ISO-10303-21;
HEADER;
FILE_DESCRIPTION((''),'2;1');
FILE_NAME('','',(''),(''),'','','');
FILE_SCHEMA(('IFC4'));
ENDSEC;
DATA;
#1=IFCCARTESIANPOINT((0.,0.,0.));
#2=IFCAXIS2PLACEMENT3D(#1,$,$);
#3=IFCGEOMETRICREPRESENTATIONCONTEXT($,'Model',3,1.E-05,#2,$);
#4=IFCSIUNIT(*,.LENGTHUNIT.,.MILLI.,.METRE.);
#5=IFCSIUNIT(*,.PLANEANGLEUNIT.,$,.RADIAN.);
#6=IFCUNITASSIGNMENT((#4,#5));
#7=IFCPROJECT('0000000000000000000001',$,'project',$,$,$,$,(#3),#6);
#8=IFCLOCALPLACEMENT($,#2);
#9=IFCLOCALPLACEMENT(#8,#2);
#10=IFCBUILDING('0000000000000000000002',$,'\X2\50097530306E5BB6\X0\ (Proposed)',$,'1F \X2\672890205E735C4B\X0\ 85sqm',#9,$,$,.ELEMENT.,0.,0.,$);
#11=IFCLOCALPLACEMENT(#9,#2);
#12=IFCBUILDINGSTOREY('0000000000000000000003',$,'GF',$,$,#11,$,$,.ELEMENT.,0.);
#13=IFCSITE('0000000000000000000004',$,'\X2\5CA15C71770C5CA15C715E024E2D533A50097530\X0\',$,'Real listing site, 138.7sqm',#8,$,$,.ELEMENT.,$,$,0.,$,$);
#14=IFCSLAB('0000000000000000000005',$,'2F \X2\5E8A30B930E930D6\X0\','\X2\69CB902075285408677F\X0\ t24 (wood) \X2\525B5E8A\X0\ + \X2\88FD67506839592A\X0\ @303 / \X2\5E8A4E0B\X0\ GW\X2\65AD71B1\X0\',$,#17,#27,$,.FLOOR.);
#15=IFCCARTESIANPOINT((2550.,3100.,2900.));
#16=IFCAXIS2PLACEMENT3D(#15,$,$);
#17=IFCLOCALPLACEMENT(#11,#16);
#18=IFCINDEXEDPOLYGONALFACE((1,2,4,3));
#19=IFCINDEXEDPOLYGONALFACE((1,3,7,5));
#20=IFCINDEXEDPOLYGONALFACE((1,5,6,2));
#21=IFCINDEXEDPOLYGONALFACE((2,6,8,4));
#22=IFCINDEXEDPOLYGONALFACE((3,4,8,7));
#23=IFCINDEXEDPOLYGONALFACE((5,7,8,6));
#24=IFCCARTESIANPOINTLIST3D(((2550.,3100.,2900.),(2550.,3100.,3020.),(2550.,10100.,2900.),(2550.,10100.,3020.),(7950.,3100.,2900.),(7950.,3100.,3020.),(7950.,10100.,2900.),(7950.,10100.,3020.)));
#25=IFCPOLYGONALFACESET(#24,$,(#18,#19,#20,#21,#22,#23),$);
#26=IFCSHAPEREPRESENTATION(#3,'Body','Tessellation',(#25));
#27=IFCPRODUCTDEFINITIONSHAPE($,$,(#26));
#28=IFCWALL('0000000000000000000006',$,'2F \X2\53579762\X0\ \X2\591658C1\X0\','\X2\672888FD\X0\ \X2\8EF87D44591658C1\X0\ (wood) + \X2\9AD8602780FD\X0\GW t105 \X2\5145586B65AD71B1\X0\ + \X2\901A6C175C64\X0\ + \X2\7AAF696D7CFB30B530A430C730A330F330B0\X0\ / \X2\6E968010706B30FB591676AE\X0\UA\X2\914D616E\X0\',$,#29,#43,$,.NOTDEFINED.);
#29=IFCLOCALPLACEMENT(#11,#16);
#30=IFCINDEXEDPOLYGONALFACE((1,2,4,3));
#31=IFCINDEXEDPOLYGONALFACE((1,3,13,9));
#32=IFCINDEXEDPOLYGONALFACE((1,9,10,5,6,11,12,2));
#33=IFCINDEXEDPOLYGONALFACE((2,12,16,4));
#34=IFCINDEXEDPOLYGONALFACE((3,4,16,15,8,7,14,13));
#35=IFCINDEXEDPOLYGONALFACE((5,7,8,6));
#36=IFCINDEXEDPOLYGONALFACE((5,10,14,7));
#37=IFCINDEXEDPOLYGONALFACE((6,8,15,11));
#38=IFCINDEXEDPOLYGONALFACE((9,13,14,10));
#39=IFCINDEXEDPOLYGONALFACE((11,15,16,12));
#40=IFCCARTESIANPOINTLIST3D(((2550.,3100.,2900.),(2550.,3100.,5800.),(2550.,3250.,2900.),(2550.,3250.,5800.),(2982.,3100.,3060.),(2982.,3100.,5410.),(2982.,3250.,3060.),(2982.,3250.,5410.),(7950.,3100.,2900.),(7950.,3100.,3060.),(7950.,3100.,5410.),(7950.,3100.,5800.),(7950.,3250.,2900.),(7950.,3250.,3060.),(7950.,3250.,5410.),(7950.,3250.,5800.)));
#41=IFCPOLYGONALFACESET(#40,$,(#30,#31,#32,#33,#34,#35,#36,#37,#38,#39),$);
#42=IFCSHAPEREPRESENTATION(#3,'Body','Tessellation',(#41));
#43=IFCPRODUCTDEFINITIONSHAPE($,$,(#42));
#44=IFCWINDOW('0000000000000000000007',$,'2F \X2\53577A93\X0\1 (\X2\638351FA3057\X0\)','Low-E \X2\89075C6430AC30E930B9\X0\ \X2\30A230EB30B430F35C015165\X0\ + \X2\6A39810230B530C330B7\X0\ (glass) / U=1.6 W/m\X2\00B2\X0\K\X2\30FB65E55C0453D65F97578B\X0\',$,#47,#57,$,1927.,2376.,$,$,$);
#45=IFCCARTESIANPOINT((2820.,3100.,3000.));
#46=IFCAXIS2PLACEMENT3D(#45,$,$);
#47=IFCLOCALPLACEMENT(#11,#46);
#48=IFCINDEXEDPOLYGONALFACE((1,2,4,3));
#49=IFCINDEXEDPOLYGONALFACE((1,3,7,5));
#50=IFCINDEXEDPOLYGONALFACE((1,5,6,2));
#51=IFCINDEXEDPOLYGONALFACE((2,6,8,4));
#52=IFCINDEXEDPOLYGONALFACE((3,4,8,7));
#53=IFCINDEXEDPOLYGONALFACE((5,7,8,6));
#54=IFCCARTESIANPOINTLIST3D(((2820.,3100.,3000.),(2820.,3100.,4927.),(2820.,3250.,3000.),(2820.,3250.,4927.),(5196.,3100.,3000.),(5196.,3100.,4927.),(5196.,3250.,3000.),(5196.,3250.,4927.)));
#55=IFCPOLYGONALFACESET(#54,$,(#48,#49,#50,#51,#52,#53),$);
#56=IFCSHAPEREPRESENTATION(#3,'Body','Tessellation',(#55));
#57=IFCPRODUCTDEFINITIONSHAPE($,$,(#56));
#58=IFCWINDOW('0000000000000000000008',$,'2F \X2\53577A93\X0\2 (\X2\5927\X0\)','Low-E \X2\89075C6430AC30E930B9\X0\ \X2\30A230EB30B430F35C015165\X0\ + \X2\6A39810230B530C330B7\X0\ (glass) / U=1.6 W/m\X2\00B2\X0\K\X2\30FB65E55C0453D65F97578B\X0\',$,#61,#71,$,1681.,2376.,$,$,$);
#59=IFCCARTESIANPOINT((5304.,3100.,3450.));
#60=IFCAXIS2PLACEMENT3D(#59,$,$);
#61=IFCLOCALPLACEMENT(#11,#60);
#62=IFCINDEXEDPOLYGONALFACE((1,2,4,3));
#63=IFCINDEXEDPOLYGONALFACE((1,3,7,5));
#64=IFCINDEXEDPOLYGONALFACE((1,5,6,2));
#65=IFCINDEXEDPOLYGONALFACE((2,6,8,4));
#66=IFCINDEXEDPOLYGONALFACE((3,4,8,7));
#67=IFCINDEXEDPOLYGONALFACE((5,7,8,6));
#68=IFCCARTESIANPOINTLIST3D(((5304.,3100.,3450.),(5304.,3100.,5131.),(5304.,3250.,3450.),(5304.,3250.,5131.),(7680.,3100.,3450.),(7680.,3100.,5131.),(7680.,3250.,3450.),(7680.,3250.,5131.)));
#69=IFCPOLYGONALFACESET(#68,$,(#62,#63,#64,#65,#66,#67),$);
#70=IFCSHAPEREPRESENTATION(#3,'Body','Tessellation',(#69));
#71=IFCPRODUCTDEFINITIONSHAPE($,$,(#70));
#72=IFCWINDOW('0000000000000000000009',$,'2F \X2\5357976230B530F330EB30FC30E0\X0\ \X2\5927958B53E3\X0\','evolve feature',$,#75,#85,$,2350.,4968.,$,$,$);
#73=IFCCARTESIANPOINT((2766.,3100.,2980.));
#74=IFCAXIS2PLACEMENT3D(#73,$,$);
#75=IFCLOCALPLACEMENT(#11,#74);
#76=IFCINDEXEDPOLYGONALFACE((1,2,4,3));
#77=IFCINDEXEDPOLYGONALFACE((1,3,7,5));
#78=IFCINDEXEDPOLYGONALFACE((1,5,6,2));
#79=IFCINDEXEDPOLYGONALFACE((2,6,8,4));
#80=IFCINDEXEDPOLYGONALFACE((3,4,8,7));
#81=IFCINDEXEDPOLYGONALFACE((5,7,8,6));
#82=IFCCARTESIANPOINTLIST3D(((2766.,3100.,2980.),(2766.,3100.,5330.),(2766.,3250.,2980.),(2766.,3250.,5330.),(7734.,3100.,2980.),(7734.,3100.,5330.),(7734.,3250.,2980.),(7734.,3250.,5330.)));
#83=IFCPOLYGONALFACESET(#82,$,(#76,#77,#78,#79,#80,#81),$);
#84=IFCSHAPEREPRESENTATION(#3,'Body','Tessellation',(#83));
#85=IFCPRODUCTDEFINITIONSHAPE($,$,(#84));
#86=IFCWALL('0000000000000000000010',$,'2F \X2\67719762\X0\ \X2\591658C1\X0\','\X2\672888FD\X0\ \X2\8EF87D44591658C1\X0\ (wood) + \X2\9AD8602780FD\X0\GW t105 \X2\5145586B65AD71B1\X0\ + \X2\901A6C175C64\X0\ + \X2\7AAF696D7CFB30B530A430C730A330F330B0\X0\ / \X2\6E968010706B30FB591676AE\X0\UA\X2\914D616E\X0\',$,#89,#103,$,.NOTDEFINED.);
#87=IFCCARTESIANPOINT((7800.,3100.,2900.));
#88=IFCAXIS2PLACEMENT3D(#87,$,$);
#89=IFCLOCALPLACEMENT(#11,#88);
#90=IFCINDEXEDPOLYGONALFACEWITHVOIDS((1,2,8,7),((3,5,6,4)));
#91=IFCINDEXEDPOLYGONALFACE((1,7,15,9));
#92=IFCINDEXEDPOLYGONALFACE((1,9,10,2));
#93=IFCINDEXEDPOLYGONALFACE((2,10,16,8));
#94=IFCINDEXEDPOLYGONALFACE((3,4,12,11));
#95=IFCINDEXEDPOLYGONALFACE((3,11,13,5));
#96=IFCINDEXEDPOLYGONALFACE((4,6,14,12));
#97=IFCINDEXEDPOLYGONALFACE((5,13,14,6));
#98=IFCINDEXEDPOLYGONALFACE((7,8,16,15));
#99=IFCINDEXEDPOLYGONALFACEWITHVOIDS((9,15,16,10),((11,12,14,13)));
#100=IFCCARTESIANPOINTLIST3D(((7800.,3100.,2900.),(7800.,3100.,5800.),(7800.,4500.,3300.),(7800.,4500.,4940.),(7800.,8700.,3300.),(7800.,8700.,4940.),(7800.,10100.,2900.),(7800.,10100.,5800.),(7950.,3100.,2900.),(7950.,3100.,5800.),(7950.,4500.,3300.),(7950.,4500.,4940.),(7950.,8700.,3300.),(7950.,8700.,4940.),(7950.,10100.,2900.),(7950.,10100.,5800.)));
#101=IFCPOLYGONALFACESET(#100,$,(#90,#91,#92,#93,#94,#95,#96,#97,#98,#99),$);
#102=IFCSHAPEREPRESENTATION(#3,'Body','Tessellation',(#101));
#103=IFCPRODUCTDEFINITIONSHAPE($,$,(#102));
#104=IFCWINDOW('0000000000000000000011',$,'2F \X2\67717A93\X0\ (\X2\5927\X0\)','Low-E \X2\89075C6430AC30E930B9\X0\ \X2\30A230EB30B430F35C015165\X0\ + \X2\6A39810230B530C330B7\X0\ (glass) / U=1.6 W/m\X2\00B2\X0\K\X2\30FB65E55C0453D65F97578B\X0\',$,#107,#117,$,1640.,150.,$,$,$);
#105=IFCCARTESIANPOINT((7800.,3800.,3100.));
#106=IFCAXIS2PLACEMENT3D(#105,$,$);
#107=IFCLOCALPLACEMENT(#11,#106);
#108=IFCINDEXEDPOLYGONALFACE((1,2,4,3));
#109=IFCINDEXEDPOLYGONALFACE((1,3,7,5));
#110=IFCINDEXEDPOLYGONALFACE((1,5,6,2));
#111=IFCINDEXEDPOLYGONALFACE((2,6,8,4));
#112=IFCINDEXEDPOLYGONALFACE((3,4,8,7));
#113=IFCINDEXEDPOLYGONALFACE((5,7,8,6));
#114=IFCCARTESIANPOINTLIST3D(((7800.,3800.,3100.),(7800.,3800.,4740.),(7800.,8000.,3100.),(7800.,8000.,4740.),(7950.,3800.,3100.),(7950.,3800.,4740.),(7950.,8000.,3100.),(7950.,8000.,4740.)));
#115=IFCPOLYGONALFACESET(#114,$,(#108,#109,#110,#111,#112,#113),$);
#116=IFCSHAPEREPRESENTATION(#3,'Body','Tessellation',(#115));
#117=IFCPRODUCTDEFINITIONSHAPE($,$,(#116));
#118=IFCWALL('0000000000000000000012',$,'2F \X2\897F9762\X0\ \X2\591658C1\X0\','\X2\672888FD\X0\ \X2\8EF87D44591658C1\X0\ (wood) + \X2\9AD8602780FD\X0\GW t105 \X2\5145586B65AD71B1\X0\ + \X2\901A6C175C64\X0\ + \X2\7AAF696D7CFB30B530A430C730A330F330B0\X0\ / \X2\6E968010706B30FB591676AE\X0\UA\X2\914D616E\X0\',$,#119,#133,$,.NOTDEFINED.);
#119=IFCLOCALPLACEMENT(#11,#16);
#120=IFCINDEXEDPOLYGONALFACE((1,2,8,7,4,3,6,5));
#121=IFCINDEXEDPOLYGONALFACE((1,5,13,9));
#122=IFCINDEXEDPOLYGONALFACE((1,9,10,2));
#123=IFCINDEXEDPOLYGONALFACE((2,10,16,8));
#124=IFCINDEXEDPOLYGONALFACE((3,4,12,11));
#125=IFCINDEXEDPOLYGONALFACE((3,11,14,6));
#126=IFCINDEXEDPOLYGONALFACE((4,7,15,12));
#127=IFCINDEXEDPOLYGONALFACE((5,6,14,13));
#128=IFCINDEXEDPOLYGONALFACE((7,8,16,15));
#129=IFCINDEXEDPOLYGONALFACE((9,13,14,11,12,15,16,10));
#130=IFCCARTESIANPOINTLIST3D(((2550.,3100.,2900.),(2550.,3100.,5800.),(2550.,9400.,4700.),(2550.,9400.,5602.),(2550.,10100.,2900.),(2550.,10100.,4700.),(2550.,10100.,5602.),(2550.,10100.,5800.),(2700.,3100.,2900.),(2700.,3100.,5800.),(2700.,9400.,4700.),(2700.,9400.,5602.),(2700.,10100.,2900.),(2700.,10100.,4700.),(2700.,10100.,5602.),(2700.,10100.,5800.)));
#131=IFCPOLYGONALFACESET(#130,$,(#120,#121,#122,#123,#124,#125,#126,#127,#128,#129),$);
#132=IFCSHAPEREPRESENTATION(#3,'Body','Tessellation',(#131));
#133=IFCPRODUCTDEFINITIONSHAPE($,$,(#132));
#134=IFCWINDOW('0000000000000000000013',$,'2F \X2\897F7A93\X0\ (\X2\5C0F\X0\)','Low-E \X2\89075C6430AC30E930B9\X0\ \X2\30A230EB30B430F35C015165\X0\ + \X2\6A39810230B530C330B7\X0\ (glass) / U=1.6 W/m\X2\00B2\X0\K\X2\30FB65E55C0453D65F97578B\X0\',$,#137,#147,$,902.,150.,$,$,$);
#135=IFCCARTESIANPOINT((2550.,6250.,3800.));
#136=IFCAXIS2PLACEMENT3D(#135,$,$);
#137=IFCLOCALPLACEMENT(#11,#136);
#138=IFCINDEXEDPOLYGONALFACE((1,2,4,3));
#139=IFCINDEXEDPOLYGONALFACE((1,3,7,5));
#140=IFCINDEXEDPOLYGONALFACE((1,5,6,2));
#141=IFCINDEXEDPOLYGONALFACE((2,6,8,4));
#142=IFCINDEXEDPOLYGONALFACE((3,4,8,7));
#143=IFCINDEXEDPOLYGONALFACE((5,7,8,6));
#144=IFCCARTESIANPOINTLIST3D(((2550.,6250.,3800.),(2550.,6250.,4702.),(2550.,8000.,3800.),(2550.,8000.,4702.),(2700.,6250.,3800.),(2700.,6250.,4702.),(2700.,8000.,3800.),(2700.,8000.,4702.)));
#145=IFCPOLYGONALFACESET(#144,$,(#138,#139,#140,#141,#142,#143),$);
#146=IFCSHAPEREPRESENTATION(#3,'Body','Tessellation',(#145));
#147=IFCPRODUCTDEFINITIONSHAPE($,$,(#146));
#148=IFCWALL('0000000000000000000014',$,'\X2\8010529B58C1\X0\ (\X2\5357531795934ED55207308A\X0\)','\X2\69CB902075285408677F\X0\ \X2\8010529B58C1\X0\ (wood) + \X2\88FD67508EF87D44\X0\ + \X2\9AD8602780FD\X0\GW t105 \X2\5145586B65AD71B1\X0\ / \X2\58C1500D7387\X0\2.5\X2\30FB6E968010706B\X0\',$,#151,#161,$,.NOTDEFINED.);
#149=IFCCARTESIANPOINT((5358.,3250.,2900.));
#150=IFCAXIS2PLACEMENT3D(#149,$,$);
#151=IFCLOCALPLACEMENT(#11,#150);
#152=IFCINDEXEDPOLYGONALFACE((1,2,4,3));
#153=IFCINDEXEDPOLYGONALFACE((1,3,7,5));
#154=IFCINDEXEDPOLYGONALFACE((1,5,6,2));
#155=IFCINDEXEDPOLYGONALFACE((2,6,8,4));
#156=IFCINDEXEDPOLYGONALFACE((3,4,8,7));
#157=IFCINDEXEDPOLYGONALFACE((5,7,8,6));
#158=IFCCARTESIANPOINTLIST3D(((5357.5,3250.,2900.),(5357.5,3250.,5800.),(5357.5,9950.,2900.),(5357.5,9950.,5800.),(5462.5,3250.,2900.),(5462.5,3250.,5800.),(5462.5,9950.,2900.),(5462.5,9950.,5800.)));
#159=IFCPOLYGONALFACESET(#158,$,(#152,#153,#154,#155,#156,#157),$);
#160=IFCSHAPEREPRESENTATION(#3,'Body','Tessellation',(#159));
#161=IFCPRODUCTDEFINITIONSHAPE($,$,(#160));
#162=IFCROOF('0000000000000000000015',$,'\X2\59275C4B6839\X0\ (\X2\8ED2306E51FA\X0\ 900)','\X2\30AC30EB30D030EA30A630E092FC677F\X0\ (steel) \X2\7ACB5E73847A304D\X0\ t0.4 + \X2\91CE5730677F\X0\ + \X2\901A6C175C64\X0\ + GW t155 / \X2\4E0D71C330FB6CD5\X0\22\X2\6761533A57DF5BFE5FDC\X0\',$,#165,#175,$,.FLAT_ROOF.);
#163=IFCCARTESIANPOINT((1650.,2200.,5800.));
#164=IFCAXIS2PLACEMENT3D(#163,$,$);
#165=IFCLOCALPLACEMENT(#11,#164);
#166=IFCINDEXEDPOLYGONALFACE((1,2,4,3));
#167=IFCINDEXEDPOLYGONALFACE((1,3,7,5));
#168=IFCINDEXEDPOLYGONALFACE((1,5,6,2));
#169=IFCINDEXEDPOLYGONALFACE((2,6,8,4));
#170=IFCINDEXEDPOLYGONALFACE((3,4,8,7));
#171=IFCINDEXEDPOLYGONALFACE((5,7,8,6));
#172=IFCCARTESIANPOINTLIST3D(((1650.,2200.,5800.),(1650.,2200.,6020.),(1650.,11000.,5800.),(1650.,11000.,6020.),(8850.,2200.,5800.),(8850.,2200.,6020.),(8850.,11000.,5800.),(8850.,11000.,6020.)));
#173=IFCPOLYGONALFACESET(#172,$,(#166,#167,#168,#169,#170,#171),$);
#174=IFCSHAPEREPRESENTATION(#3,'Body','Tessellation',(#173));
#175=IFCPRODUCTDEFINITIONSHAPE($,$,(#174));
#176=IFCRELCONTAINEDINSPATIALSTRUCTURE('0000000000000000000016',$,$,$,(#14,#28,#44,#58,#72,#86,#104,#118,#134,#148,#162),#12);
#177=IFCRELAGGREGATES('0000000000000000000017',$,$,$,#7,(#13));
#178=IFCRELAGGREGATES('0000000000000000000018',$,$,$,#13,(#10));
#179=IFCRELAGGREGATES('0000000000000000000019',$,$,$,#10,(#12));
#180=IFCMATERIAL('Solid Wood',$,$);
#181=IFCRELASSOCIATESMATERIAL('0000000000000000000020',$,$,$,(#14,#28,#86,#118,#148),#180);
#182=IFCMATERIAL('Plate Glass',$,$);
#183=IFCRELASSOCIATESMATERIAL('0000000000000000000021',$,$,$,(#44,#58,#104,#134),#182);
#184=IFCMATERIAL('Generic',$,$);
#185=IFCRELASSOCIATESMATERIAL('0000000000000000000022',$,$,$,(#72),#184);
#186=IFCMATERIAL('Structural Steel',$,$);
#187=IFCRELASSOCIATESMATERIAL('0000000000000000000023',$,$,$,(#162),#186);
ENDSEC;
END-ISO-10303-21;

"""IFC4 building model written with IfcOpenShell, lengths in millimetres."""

from ifc_helpers import new_model, si_unit, frame, frame_2d, origin, place, context, project, spatial, rectangle, extrude, material, element, fill, save


model = new_model("IFC4")

# Units and contexts
model_context = context("Model", 3, precision=1e-05, world=origin())
ifc_project = project(units=[si_unit("LENGTHUNIT", "METRE", prefix="MILLI"), si_unit("PLANEANGLEUNIT", "RADIAN")], contexts=[model_context])

# Site, building, storey
site_placement = place(None, origin())
site = spatial("IfcSite", under=ifc_project, at=site_placement, Name="岡山県岡山市中区倉田", ObjectType="Real listing site, 138.7sqm", CompositionType="ELEMENT", RefElevation=0.0)
building_placement = place(site_placement, origin())
building = spatial("IfcBuilding", under=site, at=building_placement, Name="倉田の家 (Proposed)", ObjectType="1F 木造平屋 85sqm", CompositionType="ELEMENT", ElevationOfRefHeight=0.0, ElevationOfTerrain=0.0)
storey_placement = place(building_placement, origin())
storey = spatial("IfcBuildingStorey", under=building, at=storey_placement, Name="GF", CompositionType="ELEMENT", Elevation=0.0)

# Slab
ifc_material_1 = material(Name="Solid Wood")
slab_placement = place(storey_placement, frame((2550.0, 3100.0, 2900.0)))
element("IfcSlab", 1, at=slab_placement, inside=storey, material=ifc_material_1, Name="2F 床スラブ", Description="構造用合板 t24 (wood) 剛床 + 製材根太 @303 / 床下 GW断熱", PredefinedType="FLOOR", context=model_context, shape_type="SweptSolid", body=[
    extrude(rectangle(XDim=5400.0, YDim=7000.0, at=frame_2d((2700.0, 3500.0))), frame((2550.0, 3100.0, 2900.0)), (0.0, 0.0, 1.0), 120.0),
])

# Wall, openings, windows
wall_1_placement = place(storey_placement, frame((2550.0, 3100.0, 2900.0)))
wall_1 = element("IfcWall", 2, at=wall_1_placement, inside=storey, material=ifc_material_1, Name="2F 南面 外壁", Description="木製 軸組外壁 (wood) + 高性能GW t105 充填断熱 + 通気層 + 窯業系サイディング / 準耐火・外皮UA配慮", PredefinedType="NOTDEFINED", context=model_context, shape_type="SweptSolid", body=[
    extrude(rectangle(XDim=5400.0, YDim=150.0, at=frame_2d((2700.0, 75.0))), frame((2550.0, 3100.0, 2900.0)), (0.0, 0.0, 1.0), 2900.0),
])
opening_1_placement = place(storey_placement, frame((2820.0, 3100.0, 3000.0)))
opening_1 = element("IfcOpeningElement", 3, at=opening_1_placement, cuts=wall_1, PredefinedType="NOTDEFINED", context=model_context, shape_type="SweptSolid", body=[
    extrude(rectangle(XDim=2376.0, YDim=150.0, at=frame_2d((1188.0, 75.0))), frame((2820.0, 3100.0, 3000.0)), (0.0, 0.0, 1.0), 1927.0),
])
opening_2_placement = place(storey_placement, frame((5304.0, 3100.0, 3450.0)))
opening_2 = element("IfcOpeningElement", 4, at=opening_2_placement, cuts=wall_1, PredefinedType="NOTDEFINED", context=model_context, shape_type="SweptSolid", body=[
    extrude(rectangle(XDim=2376.0, YDim=150.0, at=frame_2d((1188.0, 75.0))), frame((5304.0, 3100.0, 3450.0)), (0.0, 0.0, 1.0), 1681.0),
])
opening_3_placement = place(storey_placement, frame((2766.0, 3100.0, 2980.0)))
opening_3 = element("IfcOpeningElement", 5, at=opening_3_placement, cuts=wall_1, PredefinedType="NOTDEFINED", context=model_context, shape_type="SweptSolid", body=[
    extrude(rectangle(XDim=4968.0, YDim=150.0, at=frame_2d((2484.0, 75.0))), frame((2766.0, 3100.0, 2980.0)), (0.0, 0.0, 1.0), 2350.0),
])
ifc_material_2 = material(Name="Plate Glass")
window_1_placement = place(storey_placement, frame((2820.0, 3100.0, 3000.0)))
window_1 = element("IfcWindow", 6, at=window_1_placement, inside=storey, material=ifc_material_2, Name="2F 南窓1 (掃出し)", Description="Low-E 複層ガラス アルゴン封入 + 樹脂サッシ (glass) / U=1.6 W/m²K・日射取得型", OverallHeight=1927.0, OverallWidth=2376.0, context=model_context, shape_type="SweptSolid", body=[
    extrude(rectangle(XDim=2376.0, YDim=150.0, at=frame_2d((1188.0, 75.0))), frame((2820.0, 3100.0, 3000.0)), (0.0, 0.0, 1.0), 1927.0),
])
fill(opening_1, window_1)
window_2_placement = place(storey_placement, frame((5304.0, 3100.0, 3450.0)))
window_2 = element("IfcWindow", 7, at=window_2_placement, inside=storey, material=ifc_material_2, Name="2F 南窓2 (大)", Description="Low-E 複層ガラス アルゴン封入 + 樹脂サッシ (glass) / U=1.6 W/m²K・日射取得型", OverallHeight=1681.0, OverallWidth=2376.0, context=model_context, shape_type="SweptSolid", body=[
    extrude(rectangle(XDim=2376.0, YDim=150.0, at=frame_2d((1188.0, 75.0))), frame((5304.0, 3100.0, 3450.0)), (0.0, 0.0, 1.0), 1681.0),
])
fill(opening_2, window_2)
ifc_material_3 = material(Name="Generic")
window_3_placement = place(storey_placement, frame((2766.0, 3100.0, 2980.0)))
window_3 = element("IfcWindow", 8, at=window_3_placement, inside=storey, material=ifc_material_3, Name="2F 南面サンルーム 大開口", Description="evolve feature", OverallHeight=2350.0, OverallWidth=4968.0, context=model_context, shape_type="SweptSolid", body=[
    extrude(rectangle(XDim=4968.0, YDim=150.0, at=frame_2d((2484.0, 75.0))), frame((2766.0, 3100.0, 2980.0)), (0.0, 0.0, 1.0), 2350.0),
])
fill(opening_3, window_3)

# Walls, openings, windows
wall_2_placement = place(storey_placement, frame((7800.0, 3100.0, 2900.0)))
wall_2 = element("IfcWall", 9, at=wall_2_placement, inside=storey, material=ifc_material_1, Name="2F 東面 外壁", Description="木製 軸組外壁 (wood) + 高性能GW t105 充填断熱 + 通気層 + 窯業系サイディング / 準耐火・外皮UA配慮", PredefinedType="NOTDEFINED", context=model_context, shape_type="SweptSolid", body=[
    extrude(rectangle(XDim=150.0, YDim=7000.0, at=frame_2d((75.0, 3500.0))), frame((7800.0, 3100.0, 2900.0)), (0.0, 0.0, 1.0), 2900.0),
])
opening_4_placement = place(storey_placement, frame((7800.0, 3800.0, 3100.0)))
opening_4 = element("IfcOpeningElement", 10, at=opening_4_placement, cuts=wall_2, PredefinedType="NOTDEFINED", context=model_context, shape_type="SweptSolid", body=[
    extrude(rectangle(XDim=150.0, YDim=4200.0, at=frame_2d((75.0, 2100.0))), frame((7800.0, 3800.0, 3100.0)), (0.0, 0.0, 1.0), 1640.0),
])
window_4_placement = place(storey_placement, frame((7800.0, 3800.0, 3100.0)))
window_4 = element("IfcWindow", 11, at=window_4_placement, inside=storey, material=ifc_material_2, Name="2F 東窓 (大)", Description="Low-E 複層ガラス アルゴン封入 + 樹脂サッシ (glass) / U=1.6 W/m²K・日射取得型", OverallHeight=1640.0, OverallWidth=150.0, context=model_context, shape_type="SweptSolid", body=[
    extrude(rectangle(XDim=150.0, YDim=4200.0, at=frame_2d((75.0, 2100.0))), frame((7800.0, 3800.0, 3100.0)), (0.0, 0.0, 1.0), 1640.0),
])
fill(opening_4, window_4)
wall_3_placement = place(storey_placement, frame((2550.0, 3100.0, 2900.0)))
wall_3 = element("IfcWall", 12, at=wall_3_placement, inside=storey, material=ifc_material_1, Name="2F 西面 外壁", Description="木製 軸組外壁 (wood) + 高性能GW t105 充填断熱 + 通気層 + 窯業系サイディング / 準耐火・外皮UA配慮", PredefinedType="NOTDEFINED", context=model_context, shape_type="SweptSolid", body=[
    extrude(rectangle(XDim=150.0, YDim=7000.0, at=frame_2d((75.0, 3500.0))), frame((2550.0, 3100.0, 2900.0)), (0.0, 0.0, 1.0), 2900.0),
])
opening_5_placement = place(storey_placement, frame((2550.0, 6250.0, 3800.0)))
opening_5 = element("IfcOpeningElement", 13, at=opening_5_placement, cuts=wall_3, PredefinedType="NOTDEFINED", context=model_context, shape_type="SweptSolid", body=[
    extrude(rectangle(XDim=150.0, YDim=1750.0, at=frame_2d((75.0, 875.0))), frame((2550.0, 6250.0, 3800.0)), (0.0, 0.0, 1.0), 902.0),
])
window_5_placement = place(storey_placement, frame((2550.0, 6250.0, 3800.0)))
window_5 = element("IfcWindow", 14, at=window_5_placement, inside=storey, material=ifc_material_2, Name="2F 西窓 (小)", Description="Low-E 複層ガラス アルゴン封入 + 樹脂サッシ (glass) / U=1.6 W/m²K・日射取得型", OverallHeight=902.0, OverallWidth=150.0, context=model_context, shape_type="SweptSolid", body=[
    extrude(rectangle(XDim=150.0, YDim=1750.0, at=frame_2d((75.0, 875.0))), frame((2550.0, 6250.0, 3800.0)), (0.0, 0.0, 1.0), 902.0),
])
fill(opening_5, window_5)

# Wall
wall_4_placement = place(storey_placement, frame((5358.0, 3250.0, 2900.0)))
element("IfcWall", 15, at=wall_4_placement, inside=storey, material=ifc_material_1, Name="耐力壁 (南北間仕切り)", Description="構造用合板 耐力壁 (wood) + 製材軸組 + 高性能GW t105 充填断熱 / 壁倍率2.5・準耐火", PredefinedType="NOTDEFINED", context=model_context, shape_type="SweptSolid", body=[
    extrude(rectangle(XDim=105.0, YDim=6700.0, at=frame_2d((52.0, 3350.0))), frame((5358.0, 3250.0, 2900.0)), (0.0, 0.0, 1.0), 2900.0),
])

# Roof
ifc_material_4 = material(Name="Structural Steel")
roof_placement = place(storey_placement, frame((1650.0, 2200.0, 5800.0)))
element("IfcRoof", 16, at=roof_placement, inside=storey, material=ifc_material_4, Name="大屋根 (軒の出 900)", Description="ガルバリウム鋼板 (steel) 立平葺き t0.4 + 野地板 + 通気層 + GW t155 / 不燃・法22条区域対応", PredefinedType="FLAT_ROOF", context=model_context, shape_type="SweptSolid", body=[
    extrude(rectangle(XDim=7200.0, YDim=8800.0, at=frame_2d((3600.0, 4400.0))), frame((1650.0, 2200.0, 5800.0)), (0.0, 0.0, 1.0), 220.0),
])

save(model, "model.ifc")
